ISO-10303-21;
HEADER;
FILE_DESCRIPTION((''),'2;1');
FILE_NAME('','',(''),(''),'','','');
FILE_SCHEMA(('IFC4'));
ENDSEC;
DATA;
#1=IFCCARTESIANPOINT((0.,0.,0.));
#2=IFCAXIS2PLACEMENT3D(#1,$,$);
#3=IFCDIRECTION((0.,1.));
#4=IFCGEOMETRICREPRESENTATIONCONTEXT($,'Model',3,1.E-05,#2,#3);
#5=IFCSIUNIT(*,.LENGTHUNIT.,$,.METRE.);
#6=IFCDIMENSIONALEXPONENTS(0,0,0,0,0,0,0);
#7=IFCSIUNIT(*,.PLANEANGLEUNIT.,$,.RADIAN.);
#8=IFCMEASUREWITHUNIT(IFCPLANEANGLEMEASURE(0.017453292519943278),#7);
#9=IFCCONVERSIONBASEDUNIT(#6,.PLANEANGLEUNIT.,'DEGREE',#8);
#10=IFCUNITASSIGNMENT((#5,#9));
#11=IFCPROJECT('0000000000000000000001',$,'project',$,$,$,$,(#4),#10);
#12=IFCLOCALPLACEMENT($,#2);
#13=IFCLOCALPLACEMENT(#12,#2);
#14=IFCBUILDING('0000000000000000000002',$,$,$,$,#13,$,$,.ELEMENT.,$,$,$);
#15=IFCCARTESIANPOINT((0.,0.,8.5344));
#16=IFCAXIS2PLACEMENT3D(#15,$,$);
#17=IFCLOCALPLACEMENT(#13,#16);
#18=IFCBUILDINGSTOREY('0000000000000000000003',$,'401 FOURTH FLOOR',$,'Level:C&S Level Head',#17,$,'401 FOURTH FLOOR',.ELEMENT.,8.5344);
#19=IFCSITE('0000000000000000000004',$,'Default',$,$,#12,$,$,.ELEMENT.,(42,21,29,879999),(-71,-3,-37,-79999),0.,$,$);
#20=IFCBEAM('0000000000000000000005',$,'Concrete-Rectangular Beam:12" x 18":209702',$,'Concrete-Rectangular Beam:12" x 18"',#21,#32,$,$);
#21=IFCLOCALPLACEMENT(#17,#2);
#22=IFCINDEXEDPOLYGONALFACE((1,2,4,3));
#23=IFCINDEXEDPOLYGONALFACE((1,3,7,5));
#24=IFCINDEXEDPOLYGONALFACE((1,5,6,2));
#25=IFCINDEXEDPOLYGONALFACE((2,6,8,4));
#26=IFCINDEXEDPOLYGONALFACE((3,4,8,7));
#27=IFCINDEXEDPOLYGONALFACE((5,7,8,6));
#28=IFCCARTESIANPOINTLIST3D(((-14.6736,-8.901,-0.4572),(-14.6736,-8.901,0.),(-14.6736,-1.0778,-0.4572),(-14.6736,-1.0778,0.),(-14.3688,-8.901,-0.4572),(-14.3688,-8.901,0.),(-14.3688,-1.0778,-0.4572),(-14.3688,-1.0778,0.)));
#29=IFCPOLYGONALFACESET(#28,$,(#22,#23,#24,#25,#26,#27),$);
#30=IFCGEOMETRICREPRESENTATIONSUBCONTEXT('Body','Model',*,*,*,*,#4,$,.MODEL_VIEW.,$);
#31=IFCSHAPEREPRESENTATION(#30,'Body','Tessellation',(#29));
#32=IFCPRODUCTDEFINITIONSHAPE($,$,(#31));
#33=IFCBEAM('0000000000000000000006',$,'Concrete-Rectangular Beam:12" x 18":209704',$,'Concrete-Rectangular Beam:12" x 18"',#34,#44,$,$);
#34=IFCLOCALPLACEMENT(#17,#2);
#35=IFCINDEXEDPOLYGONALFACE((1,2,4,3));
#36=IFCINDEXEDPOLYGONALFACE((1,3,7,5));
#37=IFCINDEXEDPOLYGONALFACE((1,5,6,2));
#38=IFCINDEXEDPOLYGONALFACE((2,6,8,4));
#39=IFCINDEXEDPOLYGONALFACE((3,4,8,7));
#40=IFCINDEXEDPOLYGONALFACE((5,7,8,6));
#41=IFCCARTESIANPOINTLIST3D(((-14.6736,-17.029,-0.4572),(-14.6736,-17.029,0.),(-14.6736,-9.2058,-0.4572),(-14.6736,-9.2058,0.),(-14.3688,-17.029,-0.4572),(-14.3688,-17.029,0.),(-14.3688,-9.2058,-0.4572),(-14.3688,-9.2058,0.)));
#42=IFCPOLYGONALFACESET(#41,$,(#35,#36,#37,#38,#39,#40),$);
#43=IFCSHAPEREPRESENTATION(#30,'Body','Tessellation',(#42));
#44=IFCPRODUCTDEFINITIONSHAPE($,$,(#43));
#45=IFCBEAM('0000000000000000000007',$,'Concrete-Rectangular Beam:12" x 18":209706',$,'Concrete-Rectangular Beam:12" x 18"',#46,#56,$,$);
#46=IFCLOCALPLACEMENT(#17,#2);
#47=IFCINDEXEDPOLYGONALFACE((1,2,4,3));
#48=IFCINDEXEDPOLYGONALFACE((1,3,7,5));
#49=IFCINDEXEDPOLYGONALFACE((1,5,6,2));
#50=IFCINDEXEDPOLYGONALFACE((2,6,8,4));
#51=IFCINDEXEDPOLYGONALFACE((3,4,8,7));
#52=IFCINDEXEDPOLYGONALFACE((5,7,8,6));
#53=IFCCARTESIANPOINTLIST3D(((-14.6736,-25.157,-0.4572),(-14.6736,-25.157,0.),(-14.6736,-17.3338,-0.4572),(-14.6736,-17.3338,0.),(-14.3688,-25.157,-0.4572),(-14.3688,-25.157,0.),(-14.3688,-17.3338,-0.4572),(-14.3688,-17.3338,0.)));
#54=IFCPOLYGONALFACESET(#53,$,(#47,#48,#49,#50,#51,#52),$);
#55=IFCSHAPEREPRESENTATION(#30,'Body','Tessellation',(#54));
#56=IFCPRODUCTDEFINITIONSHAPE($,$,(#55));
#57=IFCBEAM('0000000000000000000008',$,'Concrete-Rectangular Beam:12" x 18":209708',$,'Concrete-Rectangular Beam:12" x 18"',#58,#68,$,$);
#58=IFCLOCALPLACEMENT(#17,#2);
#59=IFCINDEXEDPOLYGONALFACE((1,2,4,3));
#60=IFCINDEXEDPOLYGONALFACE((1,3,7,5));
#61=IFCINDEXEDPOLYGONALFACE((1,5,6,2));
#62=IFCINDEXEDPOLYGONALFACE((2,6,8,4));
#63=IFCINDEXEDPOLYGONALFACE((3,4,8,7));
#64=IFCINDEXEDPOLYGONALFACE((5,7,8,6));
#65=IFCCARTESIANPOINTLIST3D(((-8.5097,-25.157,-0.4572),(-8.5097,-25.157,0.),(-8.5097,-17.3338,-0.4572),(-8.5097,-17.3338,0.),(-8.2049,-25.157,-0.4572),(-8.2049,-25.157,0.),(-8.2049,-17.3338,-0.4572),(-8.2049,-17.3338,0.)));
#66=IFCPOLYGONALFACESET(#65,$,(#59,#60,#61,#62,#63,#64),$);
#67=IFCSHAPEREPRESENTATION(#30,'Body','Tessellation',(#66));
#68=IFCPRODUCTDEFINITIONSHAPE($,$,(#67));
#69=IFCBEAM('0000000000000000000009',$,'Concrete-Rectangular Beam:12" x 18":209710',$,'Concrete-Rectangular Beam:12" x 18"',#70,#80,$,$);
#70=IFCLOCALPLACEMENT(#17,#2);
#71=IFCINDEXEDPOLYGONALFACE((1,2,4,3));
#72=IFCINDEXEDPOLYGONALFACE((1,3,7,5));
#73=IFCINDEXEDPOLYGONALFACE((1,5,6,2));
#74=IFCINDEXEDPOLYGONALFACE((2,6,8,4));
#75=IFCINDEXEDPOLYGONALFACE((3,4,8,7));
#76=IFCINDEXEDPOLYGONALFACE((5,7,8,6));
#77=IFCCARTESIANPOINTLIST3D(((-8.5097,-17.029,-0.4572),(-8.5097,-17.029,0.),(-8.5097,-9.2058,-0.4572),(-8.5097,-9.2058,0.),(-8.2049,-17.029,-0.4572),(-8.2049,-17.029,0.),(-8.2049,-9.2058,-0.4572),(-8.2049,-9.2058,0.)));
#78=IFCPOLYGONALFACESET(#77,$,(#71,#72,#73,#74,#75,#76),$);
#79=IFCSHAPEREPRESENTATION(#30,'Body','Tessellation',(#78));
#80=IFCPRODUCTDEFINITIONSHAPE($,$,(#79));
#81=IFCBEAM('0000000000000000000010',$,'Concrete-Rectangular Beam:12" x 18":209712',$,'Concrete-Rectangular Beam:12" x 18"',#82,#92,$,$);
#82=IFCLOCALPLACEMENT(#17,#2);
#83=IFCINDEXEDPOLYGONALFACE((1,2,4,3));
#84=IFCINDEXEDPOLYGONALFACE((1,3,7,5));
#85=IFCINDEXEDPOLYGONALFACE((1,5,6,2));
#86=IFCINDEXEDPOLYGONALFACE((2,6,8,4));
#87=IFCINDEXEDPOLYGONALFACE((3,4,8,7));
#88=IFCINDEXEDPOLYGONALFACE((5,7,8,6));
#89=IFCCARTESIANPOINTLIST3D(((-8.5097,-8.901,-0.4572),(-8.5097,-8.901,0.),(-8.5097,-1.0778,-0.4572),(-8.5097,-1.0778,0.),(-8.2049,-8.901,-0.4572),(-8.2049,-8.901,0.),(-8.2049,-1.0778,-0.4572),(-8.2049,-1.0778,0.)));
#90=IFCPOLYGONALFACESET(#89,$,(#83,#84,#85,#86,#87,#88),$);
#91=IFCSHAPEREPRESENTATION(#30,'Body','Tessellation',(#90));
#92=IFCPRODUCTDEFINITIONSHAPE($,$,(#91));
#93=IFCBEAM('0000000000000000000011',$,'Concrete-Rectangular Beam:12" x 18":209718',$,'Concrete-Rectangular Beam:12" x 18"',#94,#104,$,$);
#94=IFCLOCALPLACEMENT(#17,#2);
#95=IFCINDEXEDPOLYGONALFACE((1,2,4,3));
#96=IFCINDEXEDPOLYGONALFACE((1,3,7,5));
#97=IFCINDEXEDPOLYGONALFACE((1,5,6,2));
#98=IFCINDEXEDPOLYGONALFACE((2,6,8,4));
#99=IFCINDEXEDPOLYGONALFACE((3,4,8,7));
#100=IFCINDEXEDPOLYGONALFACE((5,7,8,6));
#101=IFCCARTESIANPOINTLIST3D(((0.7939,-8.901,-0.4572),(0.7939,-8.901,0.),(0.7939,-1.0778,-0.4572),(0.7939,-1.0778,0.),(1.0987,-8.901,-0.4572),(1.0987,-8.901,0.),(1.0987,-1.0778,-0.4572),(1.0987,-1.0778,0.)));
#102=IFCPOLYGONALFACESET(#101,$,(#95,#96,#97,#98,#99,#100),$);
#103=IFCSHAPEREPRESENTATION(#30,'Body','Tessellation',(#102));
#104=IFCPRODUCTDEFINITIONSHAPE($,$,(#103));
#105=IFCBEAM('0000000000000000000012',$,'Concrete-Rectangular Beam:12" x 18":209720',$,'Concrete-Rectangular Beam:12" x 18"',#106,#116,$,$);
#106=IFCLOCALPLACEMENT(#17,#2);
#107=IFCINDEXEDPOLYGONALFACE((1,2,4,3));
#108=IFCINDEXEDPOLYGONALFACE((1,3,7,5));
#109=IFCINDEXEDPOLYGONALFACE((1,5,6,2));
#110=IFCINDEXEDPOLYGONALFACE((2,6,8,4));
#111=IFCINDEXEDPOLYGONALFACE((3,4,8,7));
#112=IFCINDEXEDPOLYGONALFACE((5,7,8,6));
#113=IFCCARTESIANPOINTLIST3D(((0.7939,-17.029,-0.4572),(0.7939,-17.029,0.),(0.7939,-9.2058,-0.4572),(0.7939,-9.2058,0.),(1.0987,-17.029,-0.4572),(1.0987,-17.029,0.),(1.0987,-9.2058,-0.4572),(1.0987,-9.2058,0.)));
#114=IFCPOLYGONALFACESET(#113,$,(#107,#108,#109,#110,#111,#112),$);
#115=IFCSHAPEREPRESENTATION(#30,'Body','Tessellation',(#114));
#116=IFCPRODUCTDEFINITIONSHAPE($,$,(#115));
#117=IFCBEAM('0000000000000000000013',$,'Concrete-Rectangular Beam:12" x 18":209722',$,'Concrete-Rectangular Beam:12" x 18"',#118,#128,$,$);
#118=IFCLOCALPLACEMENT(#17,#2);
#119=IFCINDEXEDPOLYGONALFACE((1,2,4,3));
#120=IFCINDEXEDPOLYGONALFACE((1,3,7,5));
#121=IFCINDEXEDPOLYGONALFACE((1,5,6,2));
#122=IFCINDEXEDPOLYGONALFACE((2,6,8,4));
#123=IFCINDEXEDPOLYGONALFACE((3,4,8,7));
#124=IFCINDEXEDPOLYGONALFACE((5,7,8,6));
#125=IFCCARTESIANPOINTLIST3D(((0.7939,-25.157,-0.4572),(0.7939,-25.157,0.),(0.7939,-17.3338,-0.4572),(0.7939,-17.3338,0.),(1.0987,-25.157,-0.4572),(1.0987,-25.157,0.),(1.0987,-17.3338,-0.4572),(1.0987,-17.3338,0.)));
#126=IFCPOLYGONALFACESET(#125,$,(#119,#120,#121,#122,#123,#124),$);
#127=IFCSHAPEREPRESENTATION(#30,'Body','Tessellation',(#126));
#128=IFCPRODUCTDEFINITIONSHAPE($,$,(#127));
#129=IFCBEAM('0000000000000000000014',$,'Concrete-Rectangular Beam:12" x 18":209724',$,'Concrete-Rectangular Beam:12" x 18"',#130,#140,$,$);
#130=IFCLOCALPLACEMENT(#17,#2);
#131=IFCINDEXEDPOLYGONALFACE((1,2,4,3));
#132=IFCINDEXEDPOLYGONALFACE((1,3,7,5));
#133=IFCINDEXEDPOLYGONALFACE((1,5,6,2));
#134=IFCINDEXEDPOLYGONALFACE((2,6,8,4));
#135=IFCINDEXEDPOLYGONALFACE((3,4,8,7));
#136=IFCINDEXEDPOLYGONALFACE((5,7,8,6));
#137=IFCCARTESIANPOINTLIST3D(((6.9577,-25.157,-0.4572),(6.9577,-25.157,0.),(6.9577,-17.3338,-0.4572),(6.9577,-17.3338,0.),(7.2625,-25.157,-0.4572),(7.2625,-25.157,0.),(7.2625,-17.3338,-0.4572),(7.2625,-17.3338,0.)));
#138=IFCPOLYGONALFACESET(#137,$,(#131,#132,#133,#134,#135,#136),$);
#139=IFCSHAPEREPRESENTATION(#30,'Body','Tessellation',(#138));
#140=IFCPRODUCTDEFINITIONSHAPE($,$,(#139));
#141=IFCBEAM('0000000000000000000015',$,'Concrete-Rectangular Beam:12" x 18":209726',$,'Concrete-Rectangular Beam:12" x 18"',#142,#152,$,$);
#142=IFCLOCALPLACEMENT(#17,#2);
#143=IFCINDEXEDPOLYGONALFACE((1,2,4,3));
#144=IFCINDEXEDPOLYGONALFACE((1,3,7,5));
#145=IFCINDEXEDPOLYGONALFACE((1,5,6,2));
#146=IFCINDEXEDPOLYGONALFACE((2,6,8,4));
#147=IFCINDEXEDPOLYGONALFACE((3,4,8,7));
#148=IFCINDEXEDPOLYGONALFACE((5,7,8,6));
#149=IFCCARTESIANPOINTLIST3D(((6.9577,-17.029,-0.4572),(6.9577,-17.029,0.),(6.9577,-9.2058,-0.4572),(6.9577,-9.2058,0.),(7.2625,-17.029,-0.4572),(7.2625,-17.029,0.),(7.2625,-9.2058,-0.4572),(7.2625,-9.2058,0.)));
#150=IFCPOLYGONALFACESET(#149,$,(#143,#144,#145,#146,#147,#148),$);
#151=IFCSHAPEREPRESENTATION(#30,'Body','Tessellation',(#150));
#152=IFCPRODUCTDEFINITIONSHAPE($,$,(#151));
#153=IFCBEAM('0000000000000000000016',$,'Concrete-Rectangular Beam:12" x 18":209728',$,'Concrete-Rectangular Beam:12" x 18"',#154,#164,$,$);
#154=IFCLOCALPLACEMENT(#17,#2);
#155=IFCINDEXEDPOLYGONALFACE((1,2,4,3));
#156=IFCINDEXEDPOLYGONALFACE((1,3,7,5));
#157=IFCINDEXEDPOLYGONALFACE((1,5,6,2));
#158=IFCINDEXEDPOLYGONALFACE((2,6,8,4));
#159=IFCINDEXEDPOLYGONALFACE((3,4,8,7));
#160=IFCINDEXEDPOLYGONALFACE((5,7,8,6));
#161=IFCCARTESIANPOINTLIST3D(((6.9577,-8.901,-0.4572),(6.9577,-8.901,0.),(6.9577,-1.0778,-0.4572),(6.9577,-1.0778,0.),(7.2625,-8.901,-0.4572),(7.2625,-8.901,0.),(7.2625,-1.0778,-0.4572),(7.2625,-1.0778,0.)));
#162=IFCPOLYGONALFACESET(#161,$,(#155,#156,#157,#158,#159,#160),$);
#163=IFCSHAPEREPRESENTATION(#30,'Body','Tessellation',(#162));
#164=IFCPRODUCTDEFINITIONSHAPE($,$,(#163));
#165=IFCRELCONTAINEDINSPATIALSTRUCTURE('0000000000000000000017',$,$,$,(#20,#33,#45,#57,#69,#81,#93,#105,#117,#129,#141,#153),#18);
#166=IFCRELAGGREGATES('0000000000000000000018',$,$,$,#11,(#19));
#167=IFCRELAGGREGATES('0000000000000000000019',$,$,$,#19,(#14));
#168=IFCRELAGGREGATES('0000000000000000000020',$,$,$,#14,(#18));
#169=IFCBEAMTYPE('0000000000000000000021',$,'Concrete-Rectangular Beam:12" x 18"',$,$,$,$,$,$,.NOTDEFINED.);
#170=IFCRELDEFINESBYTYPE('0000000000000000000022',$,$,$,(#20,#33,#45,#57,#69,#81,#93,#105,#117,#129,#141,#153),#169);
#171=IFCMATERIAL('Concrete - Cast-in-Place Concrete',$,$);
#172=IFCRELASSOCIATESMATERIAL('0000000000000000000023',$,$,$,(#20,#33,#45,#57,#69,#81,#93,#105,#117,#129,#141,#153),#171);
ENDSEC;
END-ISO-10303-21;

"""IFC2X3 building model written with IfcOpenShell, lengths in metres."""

from ifc_helpers import new_model, entity, si_unit, converted_unit, direction, frame, frame_2d, origin, origin_2d_with_axis, place, context, subcontext, project, spatial, rectangle, extrude, material, type_object, element, save


model = new_model("IFC2X3")

# Units and contexts
model_context = context("Model", 3, precision=1e-05, world=origin(), true_north=direction((0.0, 1.0)))
body_context = subcontext(model_context, "Body", "Model", "MODEL_VIEW")
ifc_project = project(units=[si_unit("LENGTHUNIT", "METRE"), converted_unit("PLANEANGLEUNIT", "DEGREE", entity("IfcPlaneAngleMeasure", 0.017453292519943278), si_unit("PLANEANGLEUNIT", "RADIAN"), dimensions=[0, 0, 0, 0, 0, 0, 0])], contexts=[model_context])

# Site, building, storey
site_placement = place(None, origin())
site = spatial("IfcSite", under=ifc_project, at=site_placement, Name="Default", CompositionType="ELEMENT", RefLatitude=(42, 21, 29, 879999), RefLongitude=(-71, -3, -37, -79999), RefElevation=0.0)
building_placement = place(site_placement, origin())
building = spatial("IfcBuilding", under=site, at=building_placement, CompositionType="ELEMENT")
storey_placement = place(building_placement, frame((0.0, 0.0, 8.5344)))
storey = spatial("IfcBuildingStorey", under=building, at=storey_placement, Name="401 FOURTH FLOOR", ObjectType="Level:C&S Level Head", LongName="401 FOURTH FLOOR", CompositionType="ELEMENT", Elevation=8.5344)

# Beams
ifc_material = material(Name="Concrete - Cast-in-Place Concrete")
beam_type = type_object("IfcBeamType", Name="Concrete-Rectangular Beam:12\" x 18\"", PredefinedType="NOTDEFINED")
beam_1_placement = place(storey_placement, frame((-14.5212, -1.0778, 0.0), z_axis=(0.0, 0.0, 1.0), x_axis=(0.0, -1.0, 0.0)))
element("IfcBeam", 1, at=beam_1_placement, inside=storey, type_object=beam_type, material=ifc_material, Name="Concrete-Rectangular Beam:12\" x 18\":209702", ObjectType="Concrete-Rectangular Beam:12\" x 18\"", context=body_context, shape_type="SweptSolid", body=[
    extrude(rectangle(XDim=0.4572, YDim=0.3048, at=origin_2d_with_axis()), frame((0.0, 0.0, -0.2286), z_axis=(1.0, 0.0, 0.0), x_axis=(0.0, 0.0, -1.0)), (0.0, 0.0, 1.0), 7.8232),
])
beam_2_placement = place(storey_placement, frame((-14.5212, -9.2058, 0.0), z_axis=(0.0, 0.0, 1.0), x_axis=(0.0, -1.0, 0.0)))
element("IfcBeam", 2, at=beam_2_placement, inside=storey, type_object=beam_type, material=ifc_material, Name="Concrete-Rectangular Beam:12\" x 18\":209704", ObjectType="Concrete-Rectangular Beam:12\" x 18\"", context=body_context, shape_type="SweptSolid", body=[
    extrude(rectangle(XDim=0.4572, YDim=0.3048, at=origin_2d_with_axis()), frame((0.0, 0.0, -0.2286), z_axis=(1.0, 0.0, 0.0), x_axis=(0.0, 0.0, -1.0)), (0.0, 0.0, 1.0), 7.8232),
])
beam_3_placement = place(storey_placement, frame((-14.5212, -17.3338, 0.0), z_axis=(0.0, 0.0, 1.0), x_axis=(0.0, -1.0, 0.0)))
element("IfcBeam", 3, at=beam_3_placement, inside=storey, type_object=beam_type, material=ifc_material, Name="Concrete-Rectangular Beam:12\" x 18\":209706", ObjectType="Concrete-Rectangular Beam:12\" x 18\"", context=body_context, shape_type="SweptSolid", body=[
    extrude(rectangle(XDim=0.4572, YDim=0.3048, at=origin_2d_with_axis()), frame((0.0, 0.0, -0.2286), z_axis=(1.0, 0.0, 0.0), x_axis=(0.0, 0.0, -1.0)), (0.0, 0.0, 1.0), 7.8232),
])
beam_4_placement = place(storey_placement, frame((-8.3573, -17.3338, 0.0), z_axis=(0.0, 0.0, 1.0), x_axis=(0.0, -1.0, 0.0)))
element("IfcBeam", 4, at=beam_4_placement, inside=storey, type_object=beam_type, material=ifc_material, Name="Concrete-Rectangular Beam:12\" x 18\":209708", ObjectType="Concrete-Rectangular Beam:12\" x 18\"", context=body_context, shape_type="SweptSolid", body=[
    extrude(rectangle(XDim=0.4572, YDim=0.3048, at=frame_2d((0.0, 0.0), x_axis=(1.0, 0.0))), frame((0.0, 0.0, -0.2286), z_axis=(1.0, 0.0, 0.0), x_axis=(0.0, 0.0, -1.0)), (0.0, 0.0, 1.0), 7.8232),
])
for number, where, z_axis, x_axis, name in (
    (5, (-8.3573, -9.2058, 0.0), (0.0, 0.0, 1.0), (0.0, -1.0, 0.0), "Concrete-Rectangular Beam:12\" x 18\":209710"),
    (6, (-8.3573, -1.0778, 0.0), (0.0, 0.0, 1.0), (0.0, -1.0, 0.0), "Concrete-Rectangular Beam:12\" x 18\":209712"),
):
    element("IfcBeam", number, at=place(storey_placement, frame(where, z_axis=z_axis, x_axis=x_axis)), inside=storey, type_object=beam_type, material=ifc_material, Name=name, ObjectType="Concrete-Rectangular Beam:12\" x 18\"", context=body_context, shape_type="SweptSolid", body=[
        extrude(rectangle(XDim=0.4572, YDim=0.3048, at=frame_2d((0.0, 0.0), x_axis=(1.0, 0.0))), frame((0.0, 0.0, -0.2286), z_axis=(1.0, 0.0, 0.0), x_axis=(0.0, 0.0, -1.0)), (0.0, 0.0, 1.0), 7.8232),
    ])
for number, where, z_axis, x_axis, name in (
    (7, (0.9463, -1.0778, 0.0), (0.0, 0.0, 1.0), (0.0, -1.0, 0.0), "Concrete-Rectangular Beam:12\" x 18\":209718"),
    (8, (0.9463, -9.2058, 0.0), (0.0, 0.0, 1.0), (0.0, -1.0, 0.0), "Concrete-Rectangular Beam:12\" x 18\":209720"),
    (9, (0.9463, -17.3338, 0.0), (0.0, 0.0, 1.0), (0.0, -1.0, 0.0), "Concrete-Rectangular Beam:12\" x 18\":209722"),
):
    element("IfcBeam", number, at=place(storey_placement, frame(where, z_axis=z_axis, x_axis=x_axis)), inside=storey, type_object=beam_type, material=ifc_material, Name=name, ObjectType="Concrete-Rectangular Beam:12\" x 18\"", context=body_context, shape_type="SweptSolid", body=[
        extrude(rectangle(XDim=0.4572, YDim=0.3048, at=origin_2d_with_axis()), frame((0.0, 0.0, -0.2286), z_axis=(1.0, 0.0, 0.0), x_axis=(0.0, 0.0, -1.0)), (0.0, 0.0, 1.0), 7.8232),
    ])
beam_5_placement = place(storey_placement, frame((7.1101, -17.3338, 0.0), z_axis=(0.0, 0.0, 1.0), x_axis=(0.0, -1.0, 0.0)))
element("IfcBeam", 10, at=beam_5_placement, inside=storey, type_object=beam_type, material=ifc_material, Name="Concrete-Rectangular Beam:12\" x 18\":209724", ObjectType="Concrete-Rectangular Beam:12\" x 18\"", context=body_context, shape_type="SweptSolid", body=[
    extrude(rectangle(XDim=0.4572, YDim=0.3048, at=frame_2d((0.0, 0.0), x_axis=(1.0, 0.0))), frame((0.0, 0.0, -0.2286), z_axis=(1.0, 0.0, 0.0), x_axis=(0.0, 0.0, -1.0)), (0.0, 0.0, 1.0), 7.8232),
])
for number, where, z_axis, x_axis, name in (
    (11, (7.1101, -9.2058, 0.0), (0.0, 0.0, 1.0), (0.0, -1.0, 0.0), "Concrete-Rectangular Beam:12\" x 18\":209726"),
    (12, (7.1101, -1.0778, 0.0), (0.0, 0.0, 1.0), (0.0, -1.0, 0.0), "Concrete-Rectangular Beam:12\" x 18\":209728"),
):
    element("IfcBeam", number, at=place(storey_placement, frame(where, z_axis=z_axis, x_axis=x_axis)), inside=storey, type_object=beam_type, material=ifc_material, Name=name, ObjectType="Concrete-Rectangular Beam:12\" x 18\"", context=body_context, shape_type="SweptSolid", body=[
        extrude(rectangle(XDim=0.4572, YDim=0.3048, at=frame_2d((0.0, 0.0), x_axis=(1.0, 0.0))), frame((0.0, 0.0, -0.2286), z_axis=(1.0, 0.0, 0.0), x_axis=(0.0, 0.0, -1.0)), (0.0, 0.0, 1.0), 7.8232),
    ])

save(model, "model.ifc")
